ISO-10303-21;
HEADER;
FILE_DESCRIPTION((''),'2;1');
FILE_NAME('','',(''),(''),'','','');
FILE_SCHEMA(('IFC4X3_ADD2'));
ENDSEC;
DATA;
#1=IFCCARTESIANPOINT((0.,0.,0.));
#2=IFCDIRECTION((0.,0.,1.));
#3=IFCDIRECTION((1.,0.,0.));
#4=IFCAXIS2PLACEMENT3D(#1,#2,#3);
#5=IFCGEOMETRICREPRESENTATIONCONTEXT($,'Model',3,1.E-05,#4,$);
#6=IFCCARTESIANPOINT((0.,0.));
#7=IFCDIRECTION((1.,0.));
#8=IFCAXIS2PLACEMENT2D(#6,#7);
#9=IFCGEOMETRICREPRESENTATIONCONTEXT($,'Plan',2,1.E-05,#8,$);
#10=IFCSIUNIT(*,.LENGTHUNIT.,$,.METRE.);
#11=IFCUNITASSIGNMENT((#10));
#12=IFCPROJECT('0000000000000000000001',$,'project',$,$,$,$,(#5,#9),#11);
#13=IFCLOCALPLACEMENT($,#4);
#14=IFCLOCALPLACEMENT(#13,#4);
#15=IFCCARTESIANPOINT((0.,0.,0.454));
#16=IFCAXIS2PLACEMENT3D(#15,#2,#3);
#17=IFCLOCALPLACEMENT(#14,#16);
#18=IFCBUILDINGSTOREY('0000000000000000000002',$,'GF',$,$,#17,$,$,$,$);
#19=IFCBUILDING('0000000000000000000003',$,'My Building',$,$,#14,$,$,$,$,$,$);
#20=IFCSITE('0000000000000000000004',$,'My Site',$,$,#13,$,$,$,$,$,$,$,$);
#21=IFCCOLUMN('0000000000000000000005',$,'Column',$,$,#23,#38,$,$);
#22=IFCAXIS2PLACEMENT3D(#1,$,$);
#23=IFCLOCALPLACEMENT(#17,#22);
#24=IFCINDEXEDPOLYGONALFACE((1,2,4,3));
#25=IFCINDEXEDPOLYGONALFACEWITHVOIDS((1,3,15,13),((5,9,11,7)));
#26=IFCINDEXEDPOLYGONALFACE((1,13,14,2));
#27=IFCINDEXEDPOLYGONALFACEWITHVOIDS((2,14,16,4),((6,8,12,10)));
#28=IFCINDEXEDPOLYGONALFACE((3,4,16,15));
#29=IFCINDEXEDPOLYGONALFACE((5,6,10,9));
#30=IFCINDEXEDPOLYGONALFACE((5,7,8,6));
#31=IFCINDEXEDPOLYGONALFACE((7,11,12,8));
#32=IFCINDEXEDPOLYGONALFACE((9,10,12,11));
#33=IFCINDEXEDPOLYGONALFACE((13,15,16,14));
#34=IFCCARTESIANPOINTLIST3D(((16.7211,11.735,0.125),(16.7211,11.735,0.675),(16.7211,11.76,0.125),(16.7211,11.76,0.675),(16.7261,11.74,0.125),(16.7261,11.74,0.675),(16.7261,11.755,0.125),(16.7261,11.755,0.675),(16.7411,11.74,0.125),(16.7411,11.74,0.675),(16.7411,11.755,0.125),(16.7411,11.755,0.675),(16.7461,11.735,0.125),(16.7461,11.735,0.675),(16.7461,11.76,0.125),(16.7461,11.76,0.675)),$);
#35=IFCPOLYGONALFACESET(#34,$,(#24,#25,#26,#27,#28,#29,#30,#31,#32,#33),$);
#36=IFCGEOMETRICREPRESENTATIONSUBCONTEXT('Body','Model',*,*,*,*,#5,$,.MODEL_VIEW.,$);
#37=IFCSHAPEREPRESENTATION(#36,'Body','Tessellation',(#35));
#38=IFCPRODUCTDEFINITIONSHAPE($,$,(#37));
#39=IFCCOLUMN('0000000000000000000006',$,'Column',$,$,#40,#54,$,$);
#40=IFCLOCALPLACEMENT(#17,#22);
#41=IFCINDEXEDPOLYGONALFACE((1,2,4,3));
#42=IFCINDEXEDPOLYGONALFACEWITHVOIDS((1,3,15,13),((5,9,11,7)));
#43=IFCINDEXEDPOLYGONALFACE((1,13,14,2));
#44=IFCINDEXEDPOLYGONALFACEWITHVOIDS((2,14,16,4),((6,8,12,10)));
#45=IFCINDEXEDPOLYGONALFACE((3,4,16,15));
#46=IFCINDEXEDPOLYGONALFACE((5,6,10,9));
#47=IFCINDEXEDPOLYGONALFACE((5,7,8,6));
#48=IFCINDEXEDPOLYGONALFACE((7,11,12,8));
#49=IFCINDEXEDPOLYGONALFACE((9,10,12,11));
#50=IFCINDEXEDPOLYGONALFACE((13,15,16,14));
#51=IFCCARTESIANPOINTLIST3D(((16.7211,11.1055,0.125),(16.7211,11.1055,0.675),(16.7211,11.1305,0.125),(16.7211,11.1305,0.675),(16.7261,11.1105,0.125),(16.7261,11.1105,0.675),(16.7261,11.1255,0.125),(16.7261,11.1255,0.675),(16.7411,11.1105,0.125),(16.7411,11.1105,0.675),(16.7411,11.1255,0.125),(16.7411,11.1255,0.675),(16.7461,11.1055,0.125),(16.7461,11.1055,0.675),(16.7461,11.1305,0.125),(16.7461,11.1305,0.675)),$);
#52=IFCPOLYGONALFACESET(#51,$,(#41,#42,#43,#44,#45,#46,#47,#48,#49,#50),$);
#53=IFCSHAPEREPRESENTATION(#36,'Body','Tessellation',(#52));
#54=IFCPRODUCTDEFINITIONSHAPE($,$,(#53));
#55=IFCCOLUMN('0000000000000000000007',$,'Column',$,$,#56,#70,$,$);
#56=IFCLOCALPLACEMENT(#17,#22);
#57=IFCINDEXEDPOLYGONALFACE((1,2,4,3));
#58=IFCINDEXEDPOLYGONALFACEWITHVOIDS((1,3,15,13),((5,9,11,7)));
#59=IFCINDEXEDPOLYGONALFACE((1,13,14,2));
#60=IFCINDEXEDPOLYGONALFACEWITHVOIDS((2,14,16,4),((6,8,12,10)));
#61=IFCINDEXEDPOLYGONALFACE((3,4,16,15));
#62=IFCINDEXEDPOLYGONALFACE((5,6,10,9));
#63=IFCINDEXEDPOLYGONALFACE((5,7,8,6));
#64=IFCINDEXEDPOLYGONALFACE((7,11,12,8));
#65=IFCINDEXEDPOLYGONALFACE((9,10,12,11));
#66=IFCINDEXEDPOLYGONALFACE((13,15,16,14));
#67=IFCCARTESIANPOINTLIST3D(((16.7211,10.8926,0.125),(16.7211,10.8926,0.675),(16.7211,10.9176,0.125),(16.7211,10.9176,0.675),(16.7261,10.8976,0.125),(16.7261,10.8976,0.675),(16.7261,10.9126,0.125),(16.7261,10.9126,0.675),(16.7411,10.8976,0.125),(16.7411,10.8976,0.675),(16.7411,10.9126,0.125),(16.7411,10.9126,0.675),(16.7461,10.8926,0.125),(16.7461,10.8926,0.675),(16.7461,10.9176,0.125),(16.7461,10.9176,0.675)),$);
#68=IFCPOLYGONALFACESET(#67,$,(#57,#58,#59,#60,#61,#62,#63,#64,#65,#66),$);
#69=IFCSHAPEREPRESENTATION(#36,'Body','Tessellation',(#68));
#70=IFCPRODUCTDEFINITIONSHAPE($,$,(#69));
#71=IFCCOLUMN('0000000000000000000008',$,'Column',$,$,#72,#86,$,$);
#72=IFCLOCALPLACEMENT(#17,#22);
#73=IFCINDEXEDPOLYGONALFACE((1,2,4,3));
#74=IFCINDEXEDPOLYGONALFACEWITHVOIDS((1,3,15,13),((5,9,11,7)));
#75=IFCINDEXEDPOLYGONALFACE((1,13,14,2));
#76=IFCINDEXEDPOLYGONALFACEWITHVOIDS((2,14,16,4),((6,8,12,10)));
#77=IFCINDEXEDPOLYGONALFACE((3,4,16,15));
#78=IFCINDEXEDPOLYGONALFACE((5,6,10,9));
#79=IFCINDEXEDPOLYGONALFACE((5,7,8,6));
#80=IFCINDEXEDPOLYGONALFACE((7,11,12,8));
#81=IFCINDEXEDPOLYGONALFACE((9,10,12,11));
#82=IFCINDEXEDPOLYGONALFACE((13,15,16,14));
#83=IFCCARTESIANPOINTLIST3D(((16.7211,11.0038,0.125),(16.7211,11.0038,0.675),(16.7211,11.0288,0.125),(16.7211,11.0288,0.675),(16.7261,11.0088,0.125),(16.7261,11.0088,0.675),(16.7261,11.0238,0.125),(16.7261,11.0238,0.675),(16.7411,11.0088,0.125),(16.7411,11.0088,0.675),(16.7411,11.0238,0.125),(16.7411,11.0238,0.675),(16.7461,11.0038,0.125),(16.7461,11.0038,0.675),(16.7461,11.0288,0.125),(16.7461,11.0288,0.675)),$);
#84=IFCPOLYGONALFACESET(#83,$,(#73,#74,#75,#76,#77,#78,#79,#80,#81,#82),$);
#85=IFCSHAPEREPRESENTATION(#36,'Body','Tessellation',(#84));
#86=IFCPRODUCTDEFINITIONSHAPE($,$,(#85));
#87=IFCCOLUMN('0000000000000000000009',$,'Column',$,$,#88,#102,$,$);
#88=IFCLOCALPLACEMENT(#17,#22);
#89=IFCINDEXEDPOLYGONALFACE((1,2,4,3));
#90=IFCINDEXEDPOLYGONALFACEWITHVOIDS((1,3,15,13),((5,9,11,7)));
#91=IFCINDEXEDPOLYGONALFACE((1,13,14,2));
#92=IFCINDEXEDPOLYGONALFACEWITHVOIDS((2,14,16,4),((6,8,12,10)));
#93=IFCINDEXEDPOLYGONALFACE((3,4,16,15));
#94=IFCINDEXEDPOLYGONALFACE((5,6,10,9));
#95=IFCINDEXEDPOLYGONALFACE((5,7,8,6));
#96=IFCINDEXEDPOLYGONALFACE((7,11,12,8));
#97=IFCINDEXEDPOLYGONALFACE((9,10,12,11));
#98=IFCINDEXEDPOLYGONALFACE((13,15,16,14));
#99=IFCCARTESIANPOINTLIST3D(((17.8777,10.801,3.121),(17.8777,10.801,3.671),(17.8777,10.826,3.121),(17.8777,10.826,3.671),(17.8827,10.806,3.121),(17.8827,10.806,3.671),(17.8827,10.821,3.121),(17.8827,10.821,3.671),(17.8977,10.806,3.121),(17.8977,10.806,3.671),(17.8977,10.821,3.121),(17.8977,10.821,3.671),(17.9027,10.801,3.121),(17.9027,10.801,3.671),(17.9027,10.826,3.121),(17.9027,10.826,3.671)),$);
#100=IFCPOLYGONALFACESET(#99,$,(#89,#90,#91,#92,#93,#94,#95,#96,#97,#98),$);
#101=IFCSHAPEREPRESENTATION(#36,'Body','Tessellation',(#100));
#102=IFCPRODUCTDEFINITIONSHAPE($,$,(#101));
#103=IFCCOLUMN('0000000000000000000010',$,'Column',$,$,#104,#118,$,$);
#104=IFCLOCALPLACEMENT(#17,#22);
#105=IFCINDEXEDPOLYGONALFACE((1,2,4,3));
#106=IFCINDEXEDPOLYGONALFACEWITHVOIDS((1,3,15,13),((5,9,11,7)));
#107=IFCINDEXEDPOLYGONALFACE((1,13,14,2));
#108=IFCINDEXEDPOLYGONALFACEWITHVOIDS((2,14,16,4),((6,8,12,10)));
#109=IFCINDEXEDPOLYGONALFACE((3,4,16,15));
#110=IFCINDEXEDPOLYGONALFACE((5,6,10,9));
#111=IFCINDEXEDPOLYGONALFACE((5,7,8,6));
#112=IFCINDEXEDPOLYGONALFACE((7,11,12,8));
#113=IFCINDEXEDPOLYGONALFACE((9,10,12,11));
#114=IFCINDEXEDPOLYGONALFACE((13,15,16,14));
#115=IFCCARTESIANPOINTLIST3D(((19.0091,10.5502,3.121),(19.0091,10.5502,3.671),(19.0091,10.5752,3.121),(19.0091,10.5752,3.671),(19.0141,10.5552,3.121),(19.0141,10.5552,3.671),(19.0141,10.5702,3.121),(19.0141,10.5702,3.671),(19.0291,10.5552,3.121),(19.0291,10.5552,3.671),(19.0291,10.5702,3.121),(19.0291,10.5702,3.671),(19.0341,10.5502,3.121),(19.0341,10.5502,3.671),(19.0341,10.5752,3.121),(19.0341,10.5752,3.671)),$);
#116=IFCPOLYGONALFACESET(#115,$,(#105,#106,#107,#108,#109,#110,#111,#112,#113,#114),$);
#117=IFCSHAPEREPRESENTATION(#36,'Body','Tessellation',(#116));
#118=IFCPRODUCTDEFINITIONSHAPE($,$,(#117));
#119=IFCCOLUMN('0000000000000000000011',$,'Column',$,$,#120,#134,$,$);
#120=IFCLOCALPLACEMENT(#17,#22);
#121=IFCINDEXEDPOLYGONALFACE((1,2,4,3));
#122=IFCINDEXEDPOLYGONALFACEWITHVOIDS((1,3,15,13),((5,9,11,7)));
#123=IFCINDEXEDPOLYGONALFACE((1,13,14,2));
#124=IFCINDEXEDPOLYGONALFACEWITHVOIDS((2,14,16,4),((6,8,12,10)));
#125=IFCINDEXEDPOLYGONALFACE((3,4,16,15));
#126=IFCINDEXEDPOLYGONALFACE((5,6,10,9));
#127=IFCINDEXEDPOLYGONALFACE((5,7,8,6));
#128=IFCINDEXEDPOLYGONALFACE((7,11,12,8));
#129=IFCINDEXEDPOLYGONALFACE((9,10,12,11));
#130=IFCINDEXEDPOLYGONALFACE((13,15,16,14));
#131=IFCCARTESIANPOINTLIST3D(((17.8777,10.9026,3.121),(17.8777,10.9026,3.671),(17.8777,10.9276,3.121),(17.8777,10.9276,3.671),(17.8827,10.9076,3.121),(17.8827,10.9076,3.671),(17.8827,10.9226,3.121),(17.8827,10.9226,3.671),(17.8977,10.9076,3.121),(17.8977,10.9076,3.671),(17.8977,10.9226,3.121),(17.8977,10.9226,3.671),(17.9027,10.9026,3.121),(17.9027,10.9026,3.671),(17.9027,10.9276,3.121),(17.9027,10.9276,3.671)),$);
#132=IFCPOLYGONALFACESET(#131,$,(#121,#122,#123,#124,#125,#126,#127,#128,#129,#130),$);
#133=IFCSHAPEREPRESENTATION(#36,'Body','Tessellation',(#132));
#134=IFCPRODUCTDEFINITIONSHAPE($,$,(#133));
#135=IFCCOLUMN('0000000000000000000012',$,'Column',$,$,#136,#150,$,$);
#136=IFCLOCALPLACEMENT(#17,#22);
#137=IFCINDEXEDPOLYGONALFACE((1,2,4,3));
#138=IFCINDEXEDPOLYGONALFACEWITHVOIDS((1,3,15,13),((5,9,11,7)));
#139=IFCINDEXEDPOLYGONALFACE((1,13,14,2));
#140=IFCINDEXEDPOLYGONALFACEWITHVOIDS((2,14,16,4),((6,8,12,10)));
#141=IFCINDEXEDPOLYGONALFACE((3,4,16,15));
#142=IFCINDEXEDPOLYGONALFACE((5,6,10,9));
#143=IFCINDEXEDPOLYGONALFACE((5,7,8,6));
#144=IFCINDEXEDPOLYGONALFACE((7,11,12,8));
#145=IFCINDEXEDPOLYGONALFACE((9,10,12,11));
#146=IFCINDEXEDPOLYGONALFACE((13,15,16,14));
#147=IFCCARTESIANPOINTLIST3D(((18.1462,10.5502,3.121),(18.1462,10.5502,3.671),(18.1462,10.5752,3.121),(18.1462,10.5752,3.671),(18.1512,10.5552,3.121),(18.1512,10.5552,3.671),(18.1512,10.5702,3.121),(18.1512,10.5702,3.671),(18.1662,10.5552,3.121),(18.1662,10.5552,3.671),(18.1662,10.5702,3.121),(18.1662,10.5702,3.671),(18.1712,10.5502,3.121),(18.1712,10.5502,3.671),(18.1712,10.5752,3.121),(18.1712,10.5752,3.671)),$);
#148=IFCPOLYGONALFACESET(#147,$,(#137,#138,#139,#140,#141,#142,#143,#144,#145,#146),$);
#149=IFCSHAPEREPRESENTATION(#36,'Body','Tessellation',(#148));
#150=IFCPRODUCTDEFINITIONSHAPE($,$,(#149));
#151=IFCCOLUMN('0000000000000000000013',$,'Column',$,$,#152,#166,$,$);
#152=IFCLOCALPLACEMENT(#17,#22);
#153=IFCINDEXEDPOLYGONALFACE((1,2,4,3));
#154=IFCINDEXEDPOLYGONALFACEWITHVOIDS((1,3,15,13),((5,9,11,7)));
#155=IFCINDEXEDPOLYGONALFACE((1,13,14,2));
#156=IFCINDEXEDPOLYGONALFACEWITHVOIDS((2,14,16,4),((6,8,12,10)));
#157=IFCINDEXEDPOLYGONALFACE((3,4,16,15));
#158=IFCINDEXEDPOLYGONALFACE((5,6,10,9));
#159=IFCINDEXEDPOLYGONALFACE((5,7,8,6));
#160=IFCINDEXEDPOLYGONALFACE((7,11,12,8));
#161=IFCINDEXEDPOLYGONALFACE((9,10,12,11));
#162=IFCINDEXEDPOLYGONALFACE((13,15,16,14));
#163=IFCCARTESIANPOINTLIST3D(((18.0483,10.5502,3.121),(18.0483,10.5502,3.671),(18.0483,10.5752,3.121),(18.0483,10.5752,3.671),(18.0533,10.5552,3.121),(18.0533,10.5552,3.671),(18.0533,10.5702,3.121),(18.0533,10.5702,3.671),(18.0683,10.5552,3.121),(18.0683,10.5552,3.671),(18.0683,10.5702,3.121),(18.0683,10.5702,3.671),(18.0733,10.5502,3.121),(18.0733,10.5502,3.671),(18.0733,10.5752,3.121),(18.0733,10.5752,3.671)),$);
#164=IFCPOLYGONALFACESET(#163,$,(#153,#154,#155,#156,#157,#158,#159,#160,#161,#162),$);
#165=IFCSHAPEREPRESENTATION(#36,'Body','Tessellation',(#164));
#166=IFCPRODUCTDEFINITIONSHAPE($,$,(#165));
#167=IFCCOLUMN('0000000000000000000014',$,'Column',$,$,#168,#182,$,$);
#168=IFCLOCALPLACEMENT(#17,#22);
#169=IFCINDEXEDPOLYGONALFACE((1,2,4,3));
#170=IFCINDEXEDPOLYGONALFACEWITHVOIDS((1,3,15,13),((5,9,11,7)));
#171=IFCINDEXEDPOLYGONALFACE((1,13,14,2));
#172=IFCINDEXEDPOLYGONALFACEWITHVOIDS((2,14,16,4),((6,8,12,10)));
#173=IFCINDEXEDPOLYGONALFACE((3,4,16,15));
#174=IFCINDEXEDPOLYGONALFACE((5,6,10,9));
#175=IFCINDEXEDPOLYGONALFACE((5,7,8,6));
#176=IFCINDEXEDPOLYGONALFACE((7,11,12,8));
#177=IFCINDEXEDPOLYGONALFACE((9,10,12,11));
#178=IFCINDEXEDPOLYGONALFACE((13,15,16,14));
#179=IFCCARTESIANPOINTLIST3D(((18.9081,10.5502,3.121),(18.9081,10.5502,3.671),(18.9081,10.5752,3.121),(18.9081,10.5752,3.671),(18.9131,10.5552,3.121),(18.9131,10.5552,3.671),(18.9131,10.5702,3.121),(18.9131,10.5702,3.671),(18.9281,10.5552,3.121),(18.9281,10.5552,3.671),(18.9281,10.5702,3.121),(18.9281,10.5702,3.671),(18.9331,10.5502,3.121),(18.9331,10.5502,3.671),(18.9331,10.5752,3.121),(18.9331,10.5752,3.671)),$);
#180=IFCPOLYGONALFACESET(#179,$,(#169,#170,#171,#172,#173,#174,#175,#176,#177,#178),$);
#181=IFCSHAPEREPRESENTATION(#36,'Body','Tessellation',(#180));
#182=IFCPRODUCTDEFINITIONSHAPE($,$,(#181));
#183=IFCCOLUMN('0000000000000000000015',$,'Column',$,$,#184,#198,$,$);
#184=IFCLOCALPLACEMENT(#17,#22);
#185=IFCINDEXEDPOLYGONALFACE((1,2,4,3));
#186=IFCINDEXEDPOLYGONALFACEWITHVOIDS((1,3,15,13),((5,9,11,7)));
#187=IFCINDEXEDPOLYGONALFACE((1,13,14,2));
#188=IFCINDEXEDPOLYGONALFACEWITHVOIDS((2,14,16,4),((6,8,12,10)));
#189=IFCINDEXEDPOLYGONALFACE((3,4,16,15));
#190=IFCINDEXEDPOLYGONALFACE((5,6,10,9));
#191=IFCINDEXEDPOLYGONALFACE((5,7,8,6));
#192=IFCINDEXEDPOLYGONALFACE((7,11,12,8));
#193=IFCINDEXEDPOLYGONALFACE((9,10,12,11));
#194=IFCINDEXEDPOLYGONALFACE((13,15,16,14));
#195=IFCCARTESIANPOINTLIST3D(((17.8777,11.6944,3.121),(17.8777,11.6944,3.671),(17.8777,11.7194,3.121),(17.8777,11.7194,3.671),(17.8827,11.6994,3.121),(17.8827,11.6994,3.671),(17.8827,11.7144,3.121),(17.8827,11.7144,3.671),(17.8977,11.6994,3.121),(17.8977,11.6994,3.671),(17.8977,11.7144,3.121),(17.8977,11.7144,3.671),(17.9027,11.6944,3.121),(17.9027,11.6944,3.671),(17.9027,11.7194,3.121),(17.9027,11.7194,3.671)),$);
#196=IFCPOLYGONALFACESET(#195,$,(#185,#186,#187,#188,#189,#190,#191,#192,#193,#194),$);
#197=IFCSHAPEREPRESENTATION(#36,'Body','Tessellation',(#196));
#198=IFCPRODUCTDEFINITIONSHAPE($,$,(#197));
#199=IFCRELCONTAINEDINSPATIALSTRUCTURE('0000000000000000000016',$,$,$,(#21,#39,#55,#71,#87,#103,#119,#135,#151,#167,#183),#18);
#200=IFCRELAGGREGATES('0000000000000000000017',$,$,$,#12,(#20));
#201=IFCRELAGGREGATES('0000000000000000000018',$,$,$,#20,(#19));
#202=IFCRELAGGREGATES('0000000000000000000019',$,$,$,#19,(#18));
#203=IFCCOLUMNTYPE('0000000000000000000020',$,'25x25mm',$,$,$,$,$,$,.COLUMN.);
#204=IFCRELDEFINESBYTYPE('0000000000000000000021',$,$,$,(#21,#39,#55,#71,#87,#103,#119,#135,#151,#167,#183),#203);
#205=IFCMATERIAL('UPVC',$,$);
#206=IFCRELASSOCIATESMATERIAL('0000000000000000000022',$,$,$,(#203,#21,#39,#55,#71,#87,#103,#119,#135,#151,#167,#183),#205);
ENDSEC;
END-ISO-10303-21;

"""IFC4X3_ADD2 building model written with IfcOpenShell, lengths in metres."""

from ifc_helpers import new_model, si_unit, frame, origin_with_axes, origin_2d_with_axis, place, context, subcontext, project, spatial, hollow_rectangle, extrude, material, material_profile, profile_set, profile_usage, type_object, element, save


model = new_model("IFC4X3_ADD2")

# Units and contexts
model_context = context("Model", 3, precision=1e-05, world=origin_with_axes())
plan_context = context("Plan", 2, precision=1e-05, world=origin_2d_with_axis())
body_context = subcontext(model_context, "Body", "Model", "MODEL_VIEW")
ifc_project = project(units=[si_unit("LENGTHUNIT", "METRE")], contexts=[model_context, plan_context])

# Site, building, storey
site_placement = place(None, origin_with_axes())
site = spatial("IfcSite", under=ifc_project, at=site_placement, Name="My Site")
building_placement = place(site_placement, origin_with_axes())
building = spatial("IfcBuilding", under=site, at=building_placement, Name="My Building")
storey_placement = place(building_placement, frame((0.0, 0.0, 0.454), z_axis=(0.0, 0.0, 1.0), x_axis=(1.0, 0.0, 0.0)))
storey = spatial("IfcBuildingStorey", under=building, at=storey_placement, Name="GF")

# Columns
ifc_material_1 = material(Name="UPVC")
ifc_material_profile_1 = material_profile(ifc_material_1, hollow_rectangle(XDim=0.025, YDim=0.025, WallThickness=0.005))
ifc_profile_set_1 = profile_set([ifc_material_profile_1])
ifc_profile_usage_1 = profile_usage(ifc_profile_set_1)
column_type_1 = type_object("IfcColumnType", Name="25x25mm", PredefinedType="COLUMN", material=ifc_profile_set_1)
column_1_placement = place(storey_placement, frame((16.7336, 11.7475, 0.125), z_axis=(0.0, 0.0, 1.0), x_axis=(0.0, -1.0, 0.0)))
element("IfcColumn", 1, at=column_1_placement, inside=storey, type_object=column_type_1, material=ifc_profile_usage_1, Name="Column", context=body_context, shape_type="SweptSolid", body=[
    extrude(hollow_rectangle(XDim=0.025, YDim=0.025, WallThickness=0.005), origin_with_axes(), (0.0, 0.0, 1.0), 0.55),
])
ifc_profile_usage_2 = profile_usage(ifc_profile_set_1)
column_2_placement = place(storey_placement, frame((16.7336, 11.118, 0.125), z_axis=(0.0, 0.0, 1.0), x_axis=(0.0, -1.0, 0.0)))
element("IfcColumn", 2, at=column_2_placement, inside=storey, type_object=column_type_1, material=ifc_profile_usage_2, Name="Column", context=body_context, shape_type="SweptSolid", body=[
    extrude(hollow_rectangle(XDim=0.025, YDim=0.025, WallThickness=0.005), origin_with_axes(), (0.0, 0.0, 1.0), 0.55),
])
ifc_profile_usage_3 = profile_usage(ifc_profile_set_1)
column_3_placement = place(storey_placement, frame((16.7336, 10.9051, 0.125), z_axis=(0.0, 0.0, 1.0), x_axis=(0.0, -1.0, 0.0)))
element("IfcColumn", 3, at=column_3_placement, inside=storey, type_object=column_type_1, material=ifc_profile_usage_3, Name="Column", context=body_context, shape_type="SweptSolid", body=[
    extrude(hollow_rectangle(XDim=0.025, YDim=0.025, WallThickness=0.005), origin_with_axes(), (0.0, 0.0, 1.0), 0.55),
])
ifc_profile_usage_4 = profile_usage(ifc_profile_set_1)
column_4_placement = place(storey_placement, frame((16.7336, 11.0163, 0.125), z_axis=(0.0, 0.0, 1.0), x_axis=(0.0, -1.0, 0.0)))
element("IfcColumn", 4, at=column_4_placement, inside=storey, type_object=column_type_1, material=ifc_profile_usage_4, Name="Column", context=body_context, shape_type="SweptSolid", body=[
    extrude(hollow_rectangle(XDim=0.025, YDim=0.025, WallThickness=0.005), origin_with_axes(), (0.0, 0.0, 1.0), 0.55),
])
ifc_profile_usage_5 = profile_usage(ifc_profile_set_1)
column_5_placement = place(storey_placement, frame((17.8902, 10.8135, 3.121), z_axis=(0.0, 0.0, 1.0), x_axis=(0.0, -1.0, 0.0)))
element("IfcColumn", 5, at=column_5_placement, inside=storey, type_object=column_type_1, material=ifc_profile_usage_5, Name="Column", context=body_context, shape_type="SweptSolid", body=[
    extrude(hollow_rectangle(XDim=0.025, YDim=0.025, WallThickness=0.005), origin_with_axes(), (0.0, 0.0, 1.0), 0.55),
])
ifc_profile_usage_6 = profile_usage(ifc_profile_set_1)
column_6_placement = place(storey_placement, frame((19.0216, 10.5627, 3.121), z_axis=(0.0, 0.0, 1.0), x_axis=(0.0, -1.0, 0.0)))
element("IfcColumn", 6, at=column_6_placement, inside=storey, type_object=column_type_1, material=ifc_profile_usage_6, Name="Column", context=body_context, shape_type="SweptSolid", body=[
    extrude(hollow_rectangle(XDim=0.025, YDim=0.025, WallThickness=0.005), origin_with_axes(), (0.0, 0.0, 1.0), 0.55),
])
ifc_profile_usage_7 = profile_usage(ifc_profile_set_1)
column_7_placement = place(storey_placement, frame((17.8902, 10.9151, 3.121), z_axis=(0.0, 0.0, 1.0), x_axis=(0.0, -1.0, 0.0)))
element("IfcColumn", 7, at=column_7_placement, inside=storey, type_object=column_type_1, material=ifc_profile_usage_7, Name="Column", context=body_context, shape_type="SweptSolid", body=[
    extrude(hollow_rectangle(XDim=0.025, YDim=0.025, WallThickness=0.005), origin_with_axes(), (0.0, 0.0, 1.0), 0.55),
])
ifc_profile_usage_8 = profile_usage(ifc_profile_set_1)
column_8_placement = place(storey_placement, frame((18.1587, 10.5627, 3.121), z_axis=(0.0, 0.0, 1.0), x_axis=(0.0, -1.0, 0.0)))
element("IfcColumn", 8, at=column_8_placement, inside=storey, type_object=column_type_1, material=ifc_profile_usage_8, Name="Column", context=body_context, shape_type="SweptSolid", body=[
    extrude(hollow_rectangle(XDim=0.025, YDim=0.025, WallThickness=0.005), origin_with_axes(), (0.0, 0.0, 1.0), 0.55),
])
ifc_profile_usage_9 = profile_usage(ifc_profile_set_1)
column_9_placement = place(storey_placement, frame((18.0608, 10.5627, 3.121), z_axis=(0.0, 0.0, 1.0), x_axis=(0.0, -1.0, 0.0)))
element("IfcColumn", 9, at=column_9_placement, inside=storey, type_object=column_type_1, material=ifc_profile_usage_9, Name="Column", context=body_context, shape_type="SweptSolid", body=[
    extrude(hollow_rectangle(XDim=0.025, YDim=0.025, WallThickness=0.005), origin_with_axes(), (0.0, 0.0, 1.0), 0.55),
])
ifc_profile_usage_10 = profile_usage(ifc_profile_set_1)
column_10_placement = place(storey_placement, frame((18.9206, 10.5627, 3.121), z_axis=(0.0, 0.0, 1.0), x_axis=(0.0, -1.0, 0.0)))
element("IfcColumn", 10, at=column_10_placement, inside=storey, type_object=column_type_1, material=ifc_profile_usage_10, Name="Column", context=body_context, shape_type="SweptSolid", body=[
    extrude(hollow_rectangle(XDim=0.025, YDim=0.025, WallThickness=0.005), origin_with_axes(), (0.0, 0.0, 1.0), 0.55),
])
ifc_profile_usage_11 = profile_usage(ifc_profile_set_1)
column_11_placement = place(storey_placement, frame((17.8902, 11.7069, 3.121), z_axis=(0.0, 0.0, 1.0), x_axis=(0.0, -1.0, 0.0)))
element("IfcColumn", 11, at=column_11_placement, inside=storey, type_object=column_type_1, material=ifc_profile_usage_11, Name="Column", context=body_context, shape_type="SweptSolid", body=[
    extrude(hollow_rectangle(XDim=0.025, YDim=0.025, WallThickness=0.005), origin_with_axes(), (0.0, 0.0, 1.0), 0.55),
])

save(model, "model.ifc")
